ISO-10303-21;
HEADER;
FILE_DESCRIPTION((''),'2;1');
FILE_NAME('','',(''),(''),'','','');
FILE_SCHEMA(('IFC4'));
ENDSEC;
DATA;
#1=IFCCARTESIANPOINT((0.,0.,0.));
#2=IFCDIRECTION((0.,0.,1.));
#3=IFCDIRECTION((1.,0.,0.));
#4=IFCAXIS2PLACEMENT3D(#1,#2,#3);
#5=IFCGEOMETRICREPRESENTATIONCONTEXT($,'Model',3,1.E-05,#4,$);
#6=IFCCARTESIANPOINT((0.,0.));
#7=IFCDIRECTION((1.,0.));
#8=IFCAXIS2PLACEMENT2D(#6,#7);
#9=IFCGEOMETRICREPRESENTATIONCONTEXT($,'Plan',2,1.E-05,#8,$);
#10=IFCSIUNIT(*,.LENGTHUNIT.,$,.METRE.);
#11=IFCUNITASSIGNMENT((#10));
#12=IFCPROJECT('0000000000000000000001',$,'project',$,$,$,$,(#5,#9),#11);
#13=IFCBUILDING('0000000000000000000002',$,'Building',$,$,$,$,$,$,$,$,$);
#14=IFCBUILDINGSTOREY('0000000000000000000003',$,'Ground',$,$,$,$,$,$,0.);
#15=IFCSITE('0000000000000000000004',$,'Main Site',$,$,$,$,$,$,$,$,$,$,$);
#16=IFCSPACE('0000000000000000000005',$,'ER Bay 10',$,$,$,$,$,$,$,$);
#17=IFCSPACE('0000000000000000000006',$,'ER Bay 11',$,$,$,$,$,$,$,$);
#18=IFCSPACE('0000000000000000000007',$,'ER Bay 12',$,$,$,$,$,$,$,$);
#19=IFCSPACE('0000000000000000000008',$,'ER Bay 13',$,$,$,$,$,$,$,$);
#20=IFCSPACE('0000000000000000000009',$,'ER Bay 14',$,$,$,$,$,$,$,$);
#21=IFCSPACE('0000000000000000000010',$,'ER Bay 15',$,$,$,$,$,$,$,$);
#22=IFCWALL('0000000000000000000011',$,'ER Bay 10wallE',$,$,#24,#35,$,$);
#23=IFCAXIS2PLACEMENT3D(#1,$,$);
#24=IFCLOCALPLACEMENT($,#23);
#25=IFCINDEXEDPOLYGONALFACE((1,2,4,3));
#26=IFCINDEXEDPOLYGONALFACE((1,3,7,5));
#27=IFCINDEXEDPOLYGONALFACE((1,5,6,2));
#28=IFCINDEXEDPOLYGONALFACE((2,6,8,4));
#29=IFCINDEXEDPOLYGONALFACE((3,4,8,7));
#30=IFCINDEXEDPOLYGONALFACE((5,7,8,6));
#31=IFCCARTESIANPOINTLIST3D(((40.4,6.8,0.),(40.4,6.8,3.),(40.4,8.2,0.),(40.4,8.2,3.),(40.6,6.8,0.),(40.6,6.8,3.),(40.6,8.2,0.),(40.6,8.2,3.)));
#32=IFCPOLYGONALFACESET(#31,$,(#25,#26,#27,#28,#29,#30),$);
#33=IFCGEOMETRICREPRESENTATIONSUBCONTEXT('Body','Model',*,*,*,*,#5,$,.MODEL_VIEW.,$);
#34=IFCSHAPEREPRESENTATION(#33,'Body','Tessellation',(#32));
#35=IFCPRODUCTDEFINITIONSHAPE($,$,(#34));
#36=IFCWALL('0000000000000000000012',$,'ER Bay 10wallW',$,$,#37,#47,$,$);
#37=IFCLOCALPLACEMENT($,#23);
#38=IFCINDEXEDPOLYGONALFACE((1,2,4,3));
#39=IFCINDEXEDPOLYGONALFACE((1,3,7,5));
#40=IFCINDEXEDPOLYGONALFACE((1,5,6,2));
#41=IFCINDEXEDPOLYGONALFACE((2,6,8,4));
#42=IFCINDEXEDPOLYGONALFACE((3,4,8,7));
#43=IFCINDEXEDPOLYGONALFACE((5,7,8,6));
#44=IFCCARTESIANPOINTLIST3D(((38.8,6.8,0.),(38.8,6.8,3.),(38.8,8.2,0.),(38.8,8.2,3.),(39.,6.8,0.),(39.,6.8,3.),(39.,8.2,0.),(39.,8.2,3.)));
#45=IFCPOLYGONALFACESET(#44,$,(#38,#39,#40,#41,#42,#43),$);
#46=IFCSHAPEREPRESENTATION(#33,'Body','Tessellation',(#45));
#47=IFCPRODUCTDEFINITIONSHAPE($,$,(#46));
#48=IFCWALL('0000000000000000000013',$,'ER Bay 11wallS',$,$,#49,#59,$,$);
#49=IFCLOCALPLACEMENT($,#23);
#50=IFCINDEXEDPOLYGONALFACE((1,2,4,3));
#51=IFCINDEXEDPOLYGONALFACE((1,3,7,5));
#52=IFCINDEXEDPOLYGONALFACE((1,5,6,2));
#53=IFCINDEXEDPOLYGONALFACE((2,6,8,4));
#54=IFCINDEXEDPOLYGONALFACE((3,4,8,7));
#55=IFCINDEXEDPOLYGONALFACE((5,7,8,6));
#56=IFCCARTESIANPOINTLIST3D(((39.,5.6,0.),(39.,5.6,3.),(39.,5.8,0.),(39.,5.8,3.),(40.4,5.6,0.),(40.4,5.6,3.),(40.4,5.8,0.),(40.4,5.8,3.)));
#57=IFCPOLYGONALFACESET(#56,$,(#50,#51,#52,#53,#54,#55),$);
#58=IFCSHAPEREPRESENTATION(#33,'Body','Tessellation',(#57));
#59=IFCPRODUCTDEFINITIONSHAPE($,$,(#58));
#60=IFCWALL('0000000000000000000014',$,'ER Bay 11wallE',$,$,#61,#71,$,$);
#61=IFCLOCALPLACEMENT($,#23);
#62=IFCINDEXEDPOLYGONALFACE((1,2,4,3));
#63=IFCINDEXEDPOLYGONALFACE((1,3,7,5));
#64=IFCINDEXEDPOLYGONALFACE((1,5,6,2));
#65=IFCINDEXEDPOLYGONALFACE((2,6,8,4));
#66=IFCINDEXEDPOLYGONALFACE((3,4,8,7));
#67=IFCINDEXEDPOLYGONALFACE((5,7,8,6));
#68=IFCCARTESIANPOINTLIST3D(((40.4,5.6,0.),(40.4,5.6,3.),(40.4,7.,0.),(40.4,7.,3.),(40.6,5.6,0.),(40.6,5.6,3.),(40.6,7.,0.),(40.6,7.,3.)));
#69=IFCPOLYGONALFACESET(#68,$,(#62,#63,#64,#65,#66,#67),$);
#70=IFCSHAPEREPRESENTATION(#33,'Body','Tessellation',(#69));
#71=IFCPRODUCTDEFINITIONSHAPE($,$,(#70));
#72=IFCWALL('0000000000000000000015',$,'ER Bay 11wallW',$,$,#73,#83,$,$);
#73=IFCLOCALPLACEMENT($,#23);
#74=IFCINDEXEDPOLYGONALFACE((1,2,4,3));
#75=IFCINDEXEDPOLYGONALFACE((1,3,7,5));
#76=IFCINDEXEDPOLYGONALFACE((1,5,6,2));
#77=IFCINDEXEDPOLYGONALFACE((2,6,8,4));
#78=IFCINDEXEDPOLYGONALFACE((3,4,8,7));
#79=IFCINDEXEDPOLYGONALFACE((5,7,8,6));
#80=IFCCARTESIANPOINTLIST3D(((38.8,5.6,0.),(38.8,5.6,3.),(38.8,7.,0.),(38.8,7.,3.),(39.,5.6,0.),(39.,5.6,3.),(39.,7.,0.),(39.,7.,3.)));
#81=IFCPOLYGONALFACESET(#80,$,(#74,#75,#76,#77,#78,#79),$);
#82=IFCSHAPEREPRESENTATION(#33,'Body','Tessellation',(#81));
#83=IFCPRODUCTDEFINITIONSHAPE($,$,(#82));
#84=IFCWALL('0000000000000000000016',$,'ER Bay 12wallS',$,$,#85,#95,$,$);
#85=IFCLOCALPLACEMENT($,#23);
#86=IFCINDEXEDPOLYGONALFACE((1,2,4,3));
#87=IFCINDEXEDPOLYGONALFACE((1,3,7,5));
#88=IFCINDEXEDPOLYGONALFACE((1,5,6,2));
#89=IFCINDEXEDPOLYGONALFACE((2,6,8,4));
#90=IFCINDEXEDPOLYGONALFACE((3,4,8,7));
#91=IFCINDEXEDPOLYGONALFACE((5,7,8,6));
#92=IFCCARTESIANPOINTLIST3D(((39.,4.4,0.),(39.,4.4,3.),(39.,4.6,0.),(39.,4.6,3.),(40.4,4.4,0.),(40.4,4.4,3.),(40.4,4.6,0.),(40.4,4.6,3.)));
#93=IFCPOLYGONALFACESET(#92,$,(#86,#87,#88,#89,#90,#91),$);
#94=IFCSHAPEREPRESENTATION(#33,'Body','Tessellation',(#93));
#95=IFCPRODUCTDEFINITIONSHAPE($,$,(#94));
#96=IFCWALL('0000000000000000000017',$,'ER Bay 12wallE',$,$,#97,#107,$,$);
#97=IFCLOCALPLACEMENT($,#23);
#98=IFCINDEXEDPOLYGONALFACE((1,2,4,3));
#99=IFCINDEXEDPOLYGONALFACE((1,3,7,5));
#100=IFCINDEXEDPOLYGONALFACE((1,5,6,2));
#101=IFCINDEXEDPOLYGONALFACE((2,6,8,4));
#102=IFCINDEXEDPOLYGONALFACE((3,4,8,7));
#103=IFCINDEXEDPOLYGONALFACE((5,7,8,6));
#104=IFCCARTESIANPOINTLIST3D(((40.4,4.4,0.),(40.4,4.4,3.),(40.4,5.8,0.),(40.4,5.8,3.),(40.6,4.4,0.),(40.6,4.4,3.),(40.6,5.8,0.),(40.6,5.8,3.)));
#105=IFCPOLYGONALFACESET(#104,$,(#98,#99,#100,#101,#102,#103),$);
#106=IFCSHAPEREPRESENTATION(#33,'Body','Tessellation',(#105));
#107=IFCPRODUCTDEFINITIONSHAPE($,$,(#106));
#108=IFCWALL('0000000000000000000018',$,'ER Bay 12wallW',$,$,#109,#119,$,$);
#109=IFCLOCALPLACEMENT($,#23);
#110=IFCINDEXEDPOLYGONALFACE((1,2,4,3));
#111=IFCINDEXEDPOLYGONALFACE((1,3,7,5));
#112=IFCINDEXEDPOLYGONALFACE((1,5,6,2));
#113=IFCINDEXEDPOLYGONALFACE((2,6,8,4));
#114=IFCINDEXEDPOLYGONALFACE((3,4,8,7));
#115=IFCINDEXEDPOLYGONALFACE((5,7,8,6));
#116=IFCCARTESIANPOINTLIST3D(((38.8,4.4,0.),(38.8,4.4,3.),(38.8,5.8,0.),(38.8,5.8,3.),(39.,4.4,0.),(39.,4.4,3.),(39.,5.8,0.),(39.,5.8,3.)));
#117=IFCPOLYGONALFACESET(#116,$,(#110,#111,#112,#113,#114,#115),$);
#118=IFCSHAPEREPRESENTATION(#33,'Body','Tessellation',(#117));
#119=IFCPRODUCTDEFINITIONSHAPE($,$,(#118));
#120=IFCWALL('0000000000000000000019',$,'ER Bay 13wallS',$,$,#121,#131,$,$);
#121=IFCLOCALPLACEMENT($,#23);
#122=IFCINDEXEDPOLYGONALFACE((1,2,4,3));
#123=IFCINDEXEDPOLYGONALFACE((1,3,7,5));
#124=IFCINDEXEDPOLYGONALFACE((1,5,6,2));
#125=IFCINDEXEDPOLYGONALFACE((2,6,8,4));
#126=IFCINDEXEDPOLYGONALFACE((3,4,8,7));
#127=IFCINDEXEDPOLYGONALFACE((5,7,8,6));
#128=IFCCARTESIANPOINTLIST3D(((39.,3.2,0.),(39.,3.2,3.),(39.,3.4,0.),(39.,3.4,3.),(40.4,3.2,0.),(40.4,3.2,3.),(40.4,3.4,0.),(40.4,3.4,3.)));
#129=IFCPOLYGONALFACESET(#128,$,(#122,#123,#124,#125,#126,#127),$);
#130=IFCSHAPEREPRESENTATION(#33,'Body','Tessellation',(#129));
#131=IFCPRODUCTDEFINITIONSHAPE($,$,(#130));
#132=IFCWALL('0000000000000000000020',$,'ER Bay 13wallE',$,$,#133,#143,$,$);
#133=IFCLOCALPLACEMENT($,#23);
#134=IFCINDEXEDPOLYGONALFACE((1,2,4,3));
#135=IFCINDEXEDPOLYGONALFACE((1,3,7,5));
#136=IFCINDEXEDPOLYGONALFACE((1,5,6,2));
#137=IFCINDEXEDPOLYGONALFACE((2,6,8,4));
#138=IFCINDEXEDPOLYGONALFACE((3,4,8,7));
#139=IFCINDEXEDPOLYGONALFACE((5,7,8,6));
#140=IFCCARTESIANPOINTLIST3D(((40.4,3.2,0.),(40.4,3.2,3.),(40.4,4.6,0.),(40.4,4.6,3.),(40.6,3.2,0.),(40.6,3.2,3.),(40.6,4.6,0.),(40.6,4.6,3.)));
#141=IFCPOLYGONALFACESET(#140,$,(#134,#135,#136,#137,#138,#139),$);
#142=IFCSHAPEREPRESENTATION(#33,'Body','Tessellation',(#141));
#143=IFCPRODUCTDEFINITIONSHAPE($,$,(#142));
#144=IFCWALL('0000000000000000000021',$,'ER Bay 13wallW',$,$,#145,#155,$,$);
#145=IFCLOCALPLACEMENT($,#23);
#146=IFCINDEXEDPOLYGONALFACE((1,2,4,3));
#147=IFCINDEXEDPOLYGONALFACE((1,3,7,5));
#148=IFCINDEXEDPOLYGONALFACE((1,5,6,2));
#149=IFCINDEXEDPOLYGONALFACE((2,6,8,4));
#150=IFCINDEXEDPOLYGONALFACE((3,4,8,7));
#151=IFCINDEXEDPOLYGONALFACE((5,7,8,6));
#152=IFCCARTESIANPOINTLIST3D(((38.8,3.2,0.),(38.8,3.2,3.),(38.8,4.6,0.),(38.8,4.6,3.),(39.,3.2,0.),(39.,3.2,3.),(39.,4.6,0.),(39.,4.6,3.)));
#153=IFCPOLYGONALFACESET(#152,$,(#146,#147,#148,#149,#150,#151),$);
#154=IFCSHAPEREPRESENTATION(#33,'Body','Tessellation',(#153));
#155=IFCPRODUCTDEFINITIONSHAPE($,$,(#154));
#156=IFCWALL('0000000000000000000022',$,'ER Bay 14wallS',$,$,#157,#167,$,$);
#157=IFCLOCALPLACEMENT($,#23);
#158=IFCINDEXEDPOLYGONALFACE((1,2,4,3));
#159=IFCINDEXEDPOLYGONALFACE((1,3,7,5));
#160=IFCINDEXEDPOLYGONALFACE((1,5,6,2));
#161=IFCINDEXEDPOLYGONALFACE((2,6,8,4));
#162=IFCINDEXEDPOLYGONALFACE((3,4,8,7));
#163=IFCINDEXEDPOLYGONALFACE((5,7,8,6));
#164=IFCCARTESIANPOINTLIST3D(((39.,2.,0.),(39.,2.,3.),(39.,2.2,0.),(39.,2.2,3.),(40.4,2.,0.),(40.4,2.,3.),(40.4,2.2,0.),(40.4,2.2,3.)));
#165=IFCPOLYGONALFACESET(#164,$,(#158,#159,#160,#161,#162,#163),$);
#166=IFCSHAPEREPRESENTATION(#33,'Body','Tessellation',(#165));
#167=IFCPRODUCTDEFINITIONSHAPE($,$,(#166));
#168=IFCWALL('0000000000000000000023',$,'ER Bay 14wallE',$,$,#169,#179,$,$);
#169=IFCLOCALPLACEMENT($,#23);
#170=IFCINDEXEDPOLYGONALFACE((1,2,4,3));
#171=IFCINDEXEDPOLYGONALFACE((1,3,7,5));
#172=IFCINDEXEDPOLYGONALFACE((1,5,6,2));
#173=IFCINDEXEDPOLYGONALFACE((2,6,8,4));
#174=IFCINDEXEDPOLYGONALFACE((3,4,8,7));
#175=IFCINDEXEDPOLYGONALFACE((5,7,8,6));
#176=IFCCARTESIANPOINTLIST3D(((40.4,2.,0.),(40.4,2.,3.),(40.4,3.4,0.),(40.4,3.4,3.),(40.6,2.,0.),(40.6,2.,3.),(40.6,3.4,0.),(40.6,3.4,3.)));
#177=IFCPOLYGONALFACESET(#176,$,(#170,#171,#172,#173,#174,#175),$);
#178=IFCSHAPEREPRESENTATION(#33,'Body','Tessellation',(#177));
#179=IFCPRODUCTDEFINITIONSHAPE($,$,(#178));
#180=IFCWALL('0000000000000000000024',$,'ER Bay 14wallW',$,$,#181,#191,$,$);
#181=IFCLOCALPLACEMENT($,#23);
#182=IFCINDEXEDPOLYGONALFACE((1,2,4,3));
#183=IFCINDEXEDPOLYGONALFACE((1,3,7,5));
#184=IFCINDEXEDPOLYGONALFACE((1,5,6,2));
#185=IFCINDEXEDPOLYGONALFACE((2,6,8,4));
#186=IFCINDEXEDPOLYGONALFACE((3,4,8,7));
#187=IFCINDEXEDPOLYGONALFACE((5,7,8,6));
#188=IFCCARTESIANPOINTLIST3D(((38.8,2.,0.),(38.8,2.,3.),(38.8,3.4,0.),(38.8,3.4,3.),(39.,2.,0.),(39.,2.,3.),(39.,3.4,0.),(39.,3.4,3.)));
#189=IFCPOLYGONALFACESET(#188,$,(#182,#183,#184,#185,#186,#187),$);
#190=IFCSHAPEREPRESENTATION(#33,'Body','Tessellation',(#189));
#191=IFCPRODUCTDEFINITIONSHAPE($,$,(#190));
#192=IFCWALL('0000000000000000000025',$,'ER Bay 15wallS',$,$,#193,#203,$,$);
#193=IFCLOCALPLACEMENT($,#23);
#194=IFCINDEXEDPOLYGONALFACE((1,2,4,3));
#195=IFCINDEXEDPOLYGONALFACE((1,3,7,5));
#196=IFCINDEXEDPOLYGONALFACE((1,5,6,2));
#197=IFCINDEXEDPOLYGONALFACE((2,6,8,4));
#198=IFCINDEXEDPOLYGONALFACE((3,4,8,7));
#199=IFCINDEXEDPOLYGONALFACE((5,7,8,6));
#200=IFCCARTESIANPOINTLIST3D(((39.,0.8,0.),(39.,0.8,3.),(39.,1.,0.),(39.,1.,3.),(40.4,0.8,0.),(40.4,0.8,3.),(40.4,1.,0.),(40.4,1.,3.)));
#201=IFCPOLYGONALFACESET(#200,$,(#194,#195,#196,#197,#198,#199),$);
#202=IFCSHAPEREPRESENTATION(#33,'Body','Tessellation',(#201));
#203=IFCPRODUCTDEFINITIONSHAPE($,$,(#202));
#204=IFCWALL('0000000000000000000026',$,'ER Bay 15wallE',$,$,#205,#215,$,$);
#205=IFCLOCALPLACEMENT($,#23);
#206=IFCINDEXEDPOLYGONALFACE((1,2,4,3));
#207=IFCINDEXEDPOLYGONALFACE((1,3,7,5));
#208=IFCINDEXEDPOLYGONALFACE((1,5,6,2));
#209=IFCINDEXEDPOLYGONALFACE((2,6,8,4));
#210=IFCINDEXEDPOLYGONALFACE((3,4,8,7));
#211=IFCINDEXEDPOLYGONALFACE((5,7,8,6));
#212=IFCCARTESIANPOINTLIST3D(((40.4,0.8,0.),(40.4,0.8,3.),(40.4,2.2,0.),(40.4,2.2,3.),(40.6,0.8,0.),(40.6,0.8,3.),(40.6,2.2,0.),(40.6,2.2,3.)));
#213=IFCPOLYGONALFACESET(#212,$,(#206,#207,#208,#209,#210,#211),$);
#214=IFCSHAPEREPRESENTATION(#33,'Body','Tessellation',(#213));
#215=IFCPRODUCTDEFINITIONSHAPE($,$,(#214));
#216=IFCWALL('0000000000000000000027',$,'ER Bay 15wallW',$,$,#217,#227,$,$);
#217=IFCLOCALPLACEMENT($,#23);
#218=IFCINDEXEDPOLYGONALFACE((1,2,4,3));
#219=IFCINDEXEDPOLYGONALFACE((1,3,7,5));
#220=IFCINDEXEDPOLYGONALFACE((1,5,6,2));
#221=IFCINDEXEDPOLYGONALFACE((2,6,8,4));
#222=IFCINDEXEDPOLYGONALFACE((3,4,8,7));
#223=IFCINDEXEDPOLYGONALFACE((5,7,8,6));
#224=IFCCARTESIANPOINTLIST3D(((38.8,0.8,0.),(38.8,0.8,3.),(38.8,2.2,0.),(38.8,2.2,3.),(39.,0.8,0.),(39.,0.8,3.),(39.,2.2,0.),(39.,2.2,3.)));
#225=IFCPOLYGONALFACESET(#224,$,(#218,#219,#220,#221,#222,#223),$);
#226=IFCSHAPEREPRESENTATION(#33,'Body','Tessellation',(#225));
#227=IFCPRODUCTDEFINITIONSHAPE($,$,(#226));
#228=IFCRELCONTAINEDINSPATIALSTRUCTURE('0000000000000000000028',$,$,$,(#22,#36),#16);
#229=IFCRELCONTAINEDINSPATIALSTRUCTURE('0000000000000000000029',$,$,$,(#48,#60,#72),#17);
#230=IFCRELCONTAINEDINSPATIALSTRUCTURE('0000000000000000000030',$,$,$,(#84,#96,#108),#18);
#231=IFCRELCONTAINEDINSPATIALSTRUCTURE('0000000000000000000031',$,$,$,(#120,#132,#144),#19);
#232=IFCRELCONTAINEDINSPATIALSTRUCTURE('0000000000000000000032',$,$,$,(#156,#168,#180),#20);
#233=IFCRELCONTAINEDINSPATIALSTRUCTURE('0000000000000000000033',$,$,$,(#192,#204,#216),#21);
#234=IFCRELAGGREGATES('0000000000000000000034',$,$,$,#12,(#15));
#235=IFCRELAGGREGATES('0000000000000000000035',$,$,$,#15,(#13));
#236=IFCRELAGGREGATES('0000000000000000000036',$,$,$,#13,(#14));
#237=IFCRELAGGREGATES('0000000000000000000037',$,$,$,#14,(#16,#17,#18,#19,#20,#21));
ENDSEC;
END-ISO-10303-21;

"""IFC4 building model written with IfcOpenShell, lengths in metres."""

from ifc_helpers import new_model, si_unit, frame, origin_with_axes, origin_2d_with_axis, place, context, subcontext, project, spatial, indexed_curve, outline, extrude, element, save


model = new_model("IFC4")

# Units and contexts
model_context = context("Model", 3, precision=1e-05, world=origin_with_axes())
plan_context = context("Plan", 2, precision=1e-05, world=origin_2d_with_axis())
body_context = subcontext(model_context, "Body", "Model", "MODEL_VIEW")
ifc_project = project(units=[si_unit("LENGTHUNIT", "METRE")], contexts=[model_context, plan_context])

# Site, building, storey
site = spatial("IfcSite", under=ifc_project, Name="Main Site")
building = spatial("IfcBuilding", under=site, Name="Building")
storey = spatial("IfcBuildingStorey", under=building, Name="Ground", Elevation=0.0)

# Shared definitions
space_1 = spatial("IfcSpace", under=storey, Name="ER Bay 10")

# Shared definitions
space_2 = spatial("IfcSpace", under=storey, Name="ER Bay 11")

# Shared definitions
space_3 = spatial("IfcSpace", under=storey, Name="ER Bay 12")

# Shared definitions
space_4 = spatial("IfcSpace", under=storey, Name="ER Bay 13")

# Shared definitions
space_5 = spatial("IfcSpace", under=storey, Name="ER Bay 14")

# Shared definitions
space_6 = spatial("IfcSpace", under=storey, Name="ER Bay 15")

# Walls
for number, where, z_axis, x_axis, name in (
    (1, (40.6, 6.8, 0.0), (0.0, 0.0, 1.0), (0.0, 1.0, 0.0), "ER Bay 10wallE"),
    (2, (39.0, 6.8, 0.0), (0.0, 0.0, 1.0), (0.0, 1.0, 0.0), "ER Bay 10wallW"),
):
    element("IfcWall", number, at=place(None, frame(where, z_axis=z_axis, x_axis=x_axis)), inside=space_1, Name=name, context=body_context, shape_type="SweptSolid", body=[
        extrude(outline(indexed_curve([(0.0, 0.0), (0.0, 0.2), (1.4, 0.2), (1.4, 0.0), (0.0, 0.0)], self_intersect=False)), origin_with_axes(), (0.0, 0.0, 1.0), 3.0),
    ])
for number, where, z_axis, x_axis, name in (
    (3, (39.0, 5.6, 0.0), (0.0, 0.0, 1.0), (1.0, 0.0, 0.0), "ER Bay 11wallS"),
    (4, (40.6, 5.6, 0.0), (0.0, 0.0, 1.0), (0.0, 1.0, 0.0), "ER Bay 11wallE"),
    (5, (39.0, 5.6, 0.0), (0.0, 0.0, 1.0), (0.0, 1.0, 0.0), "ER Bay 11wallW"),
):
    element("IfcWall", number, at=place(None, frame(where, z_axis=z_axis, x_axis=x_axis)), inside=space_2, Name=name, context=body_context, shape_type="SweptSolid", body=[
        extrude(outline(indexed_curve([(0.0, 0.0), (0.0, 0.2), (1.4, 0.2), (1.4, 0.0), (0.0, 0.0)], self_intersect=False)), origin_with_axes(), (0.0, 0.0, 1.0), 3.0),
    ])
for number, where, z_axis, x_axis, name in (
    (6, (39.0, 4.4, 0.0), (0.0, 0.0, 1.0), (1.0, 0.0, 0.0), "ER Bay 12wallS"),
    (7, (40.6, 4.4, 0.0), (0.0, 0.0, 1.0), (0.0, 1.0, 0.0), "ER Bay 12wallE"),
    (8, (39.0, 4.4, 0.0), (0.0, 0.0, 1.0), (0.0, 1.0, 0.0), "ER Bay 12wallW"),
):
    element("IfcWall", number, at=place(None, frame(where, z_axis=z_axis, x_axis=x_axis)), inside=space_3, Name=name, context=body_context, shape_type="SweptSolid", body=[
        extrude(outline(indexed_curve([(0.0, 0.0), (0.0, 0.2), (1.4, 0.2), (1.4, 0.0), (0.0, 0.0)], self_intersect=False)), origin_with_axes(), (0.0, 0.0, 1.0), 3.0),
    ])
for number, where, z_axis, x_axis, name in (
    (9, (39.0, 3.2, 0.0), (0.0, 0.0, 1.0), (1.0, 0.0, 0.0), "ER Bay 13wallS"),
    (10, (40.6, 3.2, 0.0), (0.0, 0.0, 1.0), (0.0, 1.0, 0.0), "ER Bay 13wallE"),
    (11, (39.0, 3.2, 0.0), (0.0, 0.0, 1.0), (0.0, 1.0, 0.0), "ER Bay 13wallW"),
):
    element("IfcWall", number, at=place(None, frame(where, z_axis=z_axis, x_axis=x_axis)), inside=space_4, Name=name, context=body_context, shape_type="SweptSolid", body=[
        extrude(outline(indexed_curve([(0.0, 0.0), (0.0, 0.2), (1.4, 0.2), (1.4, 0.0), (0.0, 0.0)], self_intersect=False)), origin_with_axes(), (0.0, 0.0, 1.0), 3.0),
    ])
for number, where, z_axis, x_axis, name in (
    (12, (39.0, 2.0, 0.0), (0.0, 0.0, 1.0), (1.0, 0.0, 0.0), "ER Bay 14wallS"),
    (13, (40.6, 2.0, 0.0), (0.0, 0.0, 1.0), (0.0, 1.0, 0.0), "ER Bay 14wallE"),
    (14, (39.0, 2.0, 0.0), (0.0, 0.0, 1.0), (0.0, 1.0, 0.0), "ER Bay 14wallW"),
):
    element("IfcWall", number, at=place(None, frame(where, z_axis=z_axis, x_axis=x_axis)), inside=space_5, Name=name, context=body_context, shape_type="SweptSolid", body=[
        extrude(outline(indexed_curve([(0.0, 0.0), (0.0, 0.2), (1.4, 0.2), (1.4, 0.0), (0.0, 0.0)], self_intersect=False)), origin_with_axes(), (0.0, 0.0, 1.0), 3.0),
    ])
for number, where, z_axis, x_axis, name in (
    (15, (39.0, 0.8, 0.0), (0.0, 0.0, 1.0), (1.0, 0.0, 0.0), "ER Bay 15wallS"),
    (16, (40.6, 0.8, 0.0), (0.0, 0.0, 1.0), (0.0, 1.0, 0.0), "ER Bay 15wallE"),
    (17, (39.0, 0.8, 0.0), (0.0, 0.0, 1.0), (0.0, 1.0, 0.0), "ER Bay 15wallW"),
):
    element("IfcWall", number, at=place(None, frame(where, z_axis=z_axis, x_axis=x_axis)), inside=space_6, Name=name, context=body_context, shape_type="SweptSolid", body=[
        extrude(outline(indexed_curve([(0.0, 0.0), (0.0, 0.2), (1.4, 0.2), (1.4, 0.0), (0.0, 0.0)], self_intersect=False)), origin_with_axes(), (0.0, 0.0, 1.0), 3.0),
    ])

save(model, "model.ifc")
